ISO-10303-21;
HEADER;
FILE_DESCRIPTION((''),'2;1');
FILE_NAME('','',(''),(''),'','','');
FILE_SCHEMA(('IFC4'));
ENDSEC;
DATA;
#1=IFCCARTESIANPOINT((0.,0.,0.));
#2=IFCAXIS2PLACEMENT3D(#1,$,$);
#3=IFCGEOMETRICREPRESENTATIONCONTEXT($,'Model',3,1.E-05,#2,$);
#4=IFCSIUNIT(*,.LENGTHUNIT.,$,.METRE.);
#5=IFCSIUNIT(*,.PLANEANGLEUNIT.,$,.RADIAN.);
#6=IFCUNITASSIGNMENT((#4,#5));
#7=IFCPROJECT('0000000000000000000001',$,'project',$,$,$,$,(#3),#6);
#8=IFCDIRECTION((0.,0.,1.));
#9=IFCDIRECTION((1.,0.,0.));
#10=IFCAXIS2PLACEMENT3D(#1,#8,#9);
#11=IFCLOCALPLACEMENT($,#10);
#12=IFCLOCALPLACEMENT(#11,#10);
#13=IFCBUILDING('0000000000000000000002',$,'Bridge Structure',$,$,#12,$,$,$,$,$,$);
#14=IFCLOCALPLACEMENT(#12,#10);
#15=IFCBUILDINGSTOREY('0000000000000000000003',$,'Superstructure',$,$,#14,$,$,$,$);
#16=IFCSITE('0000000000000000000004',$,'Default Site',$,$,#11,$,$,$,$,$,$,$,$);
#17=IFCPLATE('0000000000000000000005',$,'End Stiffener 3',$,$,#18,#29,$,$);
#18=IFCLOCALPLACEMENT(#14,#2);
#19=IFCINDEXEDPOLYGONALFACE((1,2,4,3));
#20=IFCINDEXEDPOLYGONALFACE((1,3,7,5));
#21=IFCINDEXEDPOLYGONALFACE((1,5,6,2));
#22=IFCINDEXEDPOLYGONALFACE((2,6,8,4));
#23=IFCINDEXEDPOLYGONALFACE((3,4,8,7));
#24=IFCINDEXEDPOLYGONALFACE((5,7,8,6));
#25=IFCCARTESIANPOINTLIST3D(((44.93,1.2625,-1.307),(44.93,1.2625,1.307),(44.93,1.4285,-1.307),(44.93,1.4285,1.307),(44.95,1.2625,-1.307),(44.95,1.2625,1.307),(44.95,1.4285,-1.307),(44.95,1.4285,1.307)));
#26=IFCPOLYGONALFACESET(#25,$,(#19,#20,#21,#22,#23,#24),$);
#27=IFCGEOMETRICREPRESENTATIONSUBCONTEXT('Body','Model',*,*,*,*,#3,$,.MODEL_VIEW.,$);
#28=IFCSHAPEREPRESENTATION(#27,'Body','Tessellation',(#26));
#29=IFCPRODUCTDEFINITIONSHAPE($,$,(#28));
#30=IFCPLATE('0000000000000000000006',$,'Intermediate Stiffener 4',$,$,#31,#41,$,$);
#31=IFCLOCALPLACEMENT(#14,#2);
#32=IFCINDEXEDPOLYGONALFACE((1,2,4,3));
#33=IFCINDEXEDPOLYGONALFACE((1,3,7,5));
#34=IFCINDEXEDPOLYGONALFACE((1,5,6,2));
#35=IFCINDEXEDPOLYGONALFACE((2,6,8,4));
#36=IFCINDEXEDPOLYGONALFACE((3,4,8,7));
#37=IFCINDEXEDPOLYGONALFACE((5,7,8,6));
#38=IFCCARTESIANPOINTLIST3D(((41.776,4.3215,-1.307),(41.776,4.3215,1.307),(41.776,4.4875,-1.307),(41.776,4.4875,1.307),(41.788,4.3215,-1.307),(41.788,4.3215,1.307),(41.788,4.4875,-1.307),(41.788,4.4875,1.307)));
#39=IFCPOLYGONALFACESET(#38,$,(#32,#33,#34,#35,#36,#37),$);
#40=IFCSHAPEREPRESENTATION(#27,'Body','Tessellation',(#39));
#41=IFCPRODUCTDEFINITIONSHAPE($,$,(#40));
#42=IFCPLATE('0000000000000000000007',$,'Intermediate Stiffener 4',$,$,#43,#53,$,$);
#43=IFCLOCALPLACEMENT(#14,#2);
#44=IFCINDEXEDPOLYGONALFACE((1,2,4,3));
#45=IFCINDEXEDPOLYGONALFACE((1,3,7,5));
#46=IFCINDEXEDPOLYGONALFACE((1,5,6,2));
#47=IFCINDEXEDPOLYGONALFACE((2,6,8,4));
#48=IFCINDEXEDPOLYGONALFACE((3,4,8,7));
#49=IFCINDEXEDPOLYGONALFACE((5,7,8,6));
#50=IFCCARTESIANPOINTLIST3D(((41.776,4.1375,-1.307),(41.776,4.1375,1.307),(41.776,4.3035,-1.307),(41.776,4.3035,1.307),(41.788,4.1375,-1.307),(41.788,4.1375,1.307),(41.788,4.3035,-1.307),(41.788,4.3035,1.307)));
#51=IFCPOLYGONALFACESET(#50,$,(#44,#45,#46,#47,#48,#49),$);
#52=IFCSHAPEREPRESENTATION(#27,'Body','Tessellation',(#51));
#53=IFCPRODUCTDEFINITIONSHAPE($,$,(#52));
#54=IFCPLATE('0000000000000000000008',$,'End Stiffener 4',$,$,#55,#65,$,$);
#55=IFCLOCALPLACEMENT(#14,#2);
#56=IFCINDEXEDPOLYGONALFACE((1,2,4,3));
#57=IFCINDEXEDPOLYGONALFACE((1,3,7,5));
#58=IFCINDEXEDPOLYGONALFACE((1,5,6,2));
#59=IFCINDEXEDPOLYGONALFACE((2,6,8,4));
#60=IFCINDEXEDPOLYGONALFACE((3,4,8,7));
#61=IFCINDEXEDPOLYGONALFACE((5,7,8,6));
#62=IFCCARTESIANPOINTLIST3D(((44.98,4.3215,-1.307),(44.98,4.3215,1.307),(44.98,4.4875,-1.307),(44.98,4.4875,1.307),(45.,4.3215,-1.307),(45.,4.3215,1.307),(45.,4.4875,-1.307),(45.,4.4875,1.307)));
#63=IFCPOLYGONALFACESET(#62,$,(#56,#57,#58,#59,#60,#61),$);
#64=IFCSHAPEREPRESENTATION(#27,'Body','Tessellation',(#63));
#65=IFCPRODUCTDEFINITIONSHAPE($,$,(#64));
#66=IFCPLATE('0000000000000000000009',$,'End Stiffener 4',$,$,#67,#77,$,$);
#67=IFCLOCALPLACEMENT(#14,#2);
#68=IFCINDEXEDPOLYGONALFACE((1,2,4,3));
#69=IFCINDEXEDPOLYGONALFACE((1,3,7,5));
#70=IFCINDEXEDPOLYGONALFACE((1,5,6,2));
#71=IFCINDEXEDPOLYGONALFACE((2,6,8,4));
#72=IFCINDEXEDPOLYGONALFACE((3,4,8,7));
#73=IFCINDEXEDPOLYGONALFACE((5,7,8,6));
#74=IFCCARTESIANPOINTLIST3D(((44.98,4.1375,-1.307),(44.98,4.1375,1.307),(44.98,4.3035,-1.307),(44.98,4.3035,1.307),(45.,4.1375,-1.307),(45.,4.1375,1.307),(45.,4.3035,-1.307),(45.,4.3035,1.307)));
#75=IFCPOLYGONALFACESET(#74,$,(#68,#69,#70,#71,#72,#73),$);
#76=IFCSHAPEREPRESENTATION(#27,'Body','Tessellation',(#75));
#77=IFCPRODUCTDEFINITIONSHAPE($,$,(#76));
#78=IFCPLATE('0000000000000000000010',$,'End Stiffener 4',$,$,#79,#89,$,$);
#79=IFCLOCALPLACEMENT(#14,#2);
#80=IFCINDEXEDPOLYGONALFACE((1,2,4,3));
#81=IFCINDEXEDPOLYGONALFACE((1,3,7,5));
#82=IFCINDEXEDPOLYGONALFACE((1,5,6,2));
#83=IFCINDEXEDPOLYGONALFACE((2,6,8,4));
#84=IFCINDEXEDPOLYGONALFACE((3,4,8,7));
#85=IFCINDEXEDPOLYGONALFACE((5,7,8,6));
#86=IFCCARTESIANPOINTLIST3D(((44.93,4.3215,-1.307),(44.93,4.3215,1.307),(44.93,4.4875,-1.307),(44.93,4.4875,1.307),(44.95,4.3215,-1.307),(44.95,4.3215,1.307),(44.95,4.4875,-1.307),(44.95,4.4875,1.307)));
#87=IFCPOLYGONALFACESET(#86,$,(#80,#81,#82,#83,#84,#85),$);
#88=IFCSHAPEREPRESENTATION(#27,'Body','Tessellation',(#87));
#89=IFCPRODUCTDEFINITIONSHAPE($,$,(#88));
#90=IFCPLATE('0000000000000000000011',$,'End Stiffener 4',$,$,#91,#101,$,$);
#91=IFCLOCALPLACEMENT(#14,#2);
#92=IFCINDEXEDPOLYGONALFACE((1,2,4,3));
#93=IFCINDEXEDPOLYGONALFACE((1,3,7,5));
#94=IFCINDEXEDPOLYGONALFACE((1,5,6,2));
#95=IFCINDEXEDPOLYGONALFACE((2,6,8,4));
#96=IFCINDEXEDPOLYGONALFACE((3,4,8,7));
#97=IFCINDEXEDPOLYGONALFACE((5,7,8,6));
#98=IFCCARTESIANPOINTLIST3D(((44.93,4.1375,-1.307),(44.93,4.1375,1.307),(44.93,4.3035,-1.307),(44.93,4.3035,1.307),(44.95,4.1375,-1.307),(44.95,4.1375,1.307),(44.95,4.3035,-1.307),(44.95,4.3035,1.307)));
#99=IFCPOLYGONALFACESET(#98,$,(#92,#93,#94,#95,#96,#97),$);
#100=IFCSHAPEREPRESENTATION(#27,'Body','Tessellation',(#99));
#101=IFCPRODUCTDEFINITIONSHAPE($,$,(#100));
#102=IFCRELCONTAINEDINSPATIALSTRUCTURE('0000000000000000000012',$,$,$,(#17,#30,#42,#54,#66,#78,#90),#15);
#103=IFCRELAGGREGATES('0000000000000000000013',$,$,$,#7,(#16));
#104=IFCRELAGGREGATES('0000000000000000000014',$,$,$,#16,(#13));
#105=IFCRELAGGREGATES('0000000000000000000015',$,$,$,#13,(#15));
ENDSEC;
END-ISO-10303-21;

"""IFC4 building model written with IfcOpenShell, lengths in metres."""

from ifc_helpers import new_model, si_unit, frame, origin, origin_with_axes, origin_2d_with_axis, place, context, subcontext, project, spatial, rectangle, extrude, element, save


model = new_model("IFC4")

# Units and contexts
model_context = context("Model", 3, precision=1e-05, world=origin())
body_context = subcontext(model_context, "Body", "Model", "MODEL_VIEW")
ifc_project = project(units=[si_unit("LENGTHUNIT", "METRE"), si_unit("PLANEANGLEUNIT", "RADIAN")], contexts=[model_context])

# Site, building, storey
site_placement = place(None, origin_with_axes())
site = spatial("IfcSite", under=ifc_project, at=site_placement, Name="Default Site")
building_placement = place(site_placement, origin_with_axes())
building = spatial("IfcBuilding", under=site, at=building_placement, Name="Bridge Structure")
storey_placement = place(building_placement, origin_with_axes())
storey = spatial("IfcBuildingStorey", under=building, at=storey_placement, Name="Superstructure")

# Plates
for number, where, z_axis, x_axis, name in (
    (1, (44.94, 1.3455, -1.307), (0.0, 0.0, 1.0), (1.0, 0.0, 0.0), "End Stiffener 3"),
):
    element("IfcPlate", number, at=place(storey_placement, frame(where, z_axis=z_axis, x_axis=x_axis)), inside=storey, Name=name, context=body_context, shape_type="SweptSolid", body=[
        extrude(rectangle(XDim=0.02, YDim=0.166, at=origin_2d_with_axis()), origin_with_axes(), (0.0, 0.0, 1.0), 2.614),
    ])
for number, where, z_axis, x_axis, name in (
    (2, (41.782, 4.4045, -1.307), (0.0, 0.0, 1.0), (1.0, 0.0, 0.0), "Intermediate Stiffener 4"),
    (3, (41.782, 4.2205, -1.307), (0.0, 0.0, 1.0), (1.0, 0.0, 0.0), "Intermediate Stiffener 4"),
):
    element("IfcPlate", number, at=place(storey_placement, frame(where, z_axis=z_axis, x_axis=x_axis)), inside=storey, Name=name, context=body_context, shape_type="SweptSolid", body=[
        extrude(rectangle(XDim=0.012, YDim=0.166, at=origin_2d_with_axis()), origin_with_axes(), (0.0, 0.0, 1.0), 2.614),
    ])
for number, where, z_axis, x_axis, name in (
    (4, (44.99, 4.4045, -1.307), (0.0, 0.0, 1.0), (1.0, 0.0, 0.0), "End Stiffener 4"),
    (5, (44.99, 4.2205, -1.307), (0.0, 0.0, 1.0), (1.0, 0.0, 0.0), "End Stiffener 4"),
    (6, (44.94, 4.4045, -1.307), (0.0, 0.0, 1.0), (1.0, 0.0, 0.0), "End Stiffener 4"),
    (7, (44.94, 4.2205, -1.307), (0.0, 0.0, 1.0), (1.0, 0.0, 0.0), "End Stiffener 4"),
):
    element("IfcPlate", number, at=place(storey_placement, frame(where, z_axis=z_axis, x_axis=x_axis)), inside=storey, Name=name, context=body_context, shape_type="SweptSolid", body=[
        extrude(rectangle(XDim=0.02, YDim=0.166, at=origin_2d_with_axis()), origin_with_axes(), (0.0, 0.0, 1.0), 2.614),
    ])

save(model, "model.ifc")
